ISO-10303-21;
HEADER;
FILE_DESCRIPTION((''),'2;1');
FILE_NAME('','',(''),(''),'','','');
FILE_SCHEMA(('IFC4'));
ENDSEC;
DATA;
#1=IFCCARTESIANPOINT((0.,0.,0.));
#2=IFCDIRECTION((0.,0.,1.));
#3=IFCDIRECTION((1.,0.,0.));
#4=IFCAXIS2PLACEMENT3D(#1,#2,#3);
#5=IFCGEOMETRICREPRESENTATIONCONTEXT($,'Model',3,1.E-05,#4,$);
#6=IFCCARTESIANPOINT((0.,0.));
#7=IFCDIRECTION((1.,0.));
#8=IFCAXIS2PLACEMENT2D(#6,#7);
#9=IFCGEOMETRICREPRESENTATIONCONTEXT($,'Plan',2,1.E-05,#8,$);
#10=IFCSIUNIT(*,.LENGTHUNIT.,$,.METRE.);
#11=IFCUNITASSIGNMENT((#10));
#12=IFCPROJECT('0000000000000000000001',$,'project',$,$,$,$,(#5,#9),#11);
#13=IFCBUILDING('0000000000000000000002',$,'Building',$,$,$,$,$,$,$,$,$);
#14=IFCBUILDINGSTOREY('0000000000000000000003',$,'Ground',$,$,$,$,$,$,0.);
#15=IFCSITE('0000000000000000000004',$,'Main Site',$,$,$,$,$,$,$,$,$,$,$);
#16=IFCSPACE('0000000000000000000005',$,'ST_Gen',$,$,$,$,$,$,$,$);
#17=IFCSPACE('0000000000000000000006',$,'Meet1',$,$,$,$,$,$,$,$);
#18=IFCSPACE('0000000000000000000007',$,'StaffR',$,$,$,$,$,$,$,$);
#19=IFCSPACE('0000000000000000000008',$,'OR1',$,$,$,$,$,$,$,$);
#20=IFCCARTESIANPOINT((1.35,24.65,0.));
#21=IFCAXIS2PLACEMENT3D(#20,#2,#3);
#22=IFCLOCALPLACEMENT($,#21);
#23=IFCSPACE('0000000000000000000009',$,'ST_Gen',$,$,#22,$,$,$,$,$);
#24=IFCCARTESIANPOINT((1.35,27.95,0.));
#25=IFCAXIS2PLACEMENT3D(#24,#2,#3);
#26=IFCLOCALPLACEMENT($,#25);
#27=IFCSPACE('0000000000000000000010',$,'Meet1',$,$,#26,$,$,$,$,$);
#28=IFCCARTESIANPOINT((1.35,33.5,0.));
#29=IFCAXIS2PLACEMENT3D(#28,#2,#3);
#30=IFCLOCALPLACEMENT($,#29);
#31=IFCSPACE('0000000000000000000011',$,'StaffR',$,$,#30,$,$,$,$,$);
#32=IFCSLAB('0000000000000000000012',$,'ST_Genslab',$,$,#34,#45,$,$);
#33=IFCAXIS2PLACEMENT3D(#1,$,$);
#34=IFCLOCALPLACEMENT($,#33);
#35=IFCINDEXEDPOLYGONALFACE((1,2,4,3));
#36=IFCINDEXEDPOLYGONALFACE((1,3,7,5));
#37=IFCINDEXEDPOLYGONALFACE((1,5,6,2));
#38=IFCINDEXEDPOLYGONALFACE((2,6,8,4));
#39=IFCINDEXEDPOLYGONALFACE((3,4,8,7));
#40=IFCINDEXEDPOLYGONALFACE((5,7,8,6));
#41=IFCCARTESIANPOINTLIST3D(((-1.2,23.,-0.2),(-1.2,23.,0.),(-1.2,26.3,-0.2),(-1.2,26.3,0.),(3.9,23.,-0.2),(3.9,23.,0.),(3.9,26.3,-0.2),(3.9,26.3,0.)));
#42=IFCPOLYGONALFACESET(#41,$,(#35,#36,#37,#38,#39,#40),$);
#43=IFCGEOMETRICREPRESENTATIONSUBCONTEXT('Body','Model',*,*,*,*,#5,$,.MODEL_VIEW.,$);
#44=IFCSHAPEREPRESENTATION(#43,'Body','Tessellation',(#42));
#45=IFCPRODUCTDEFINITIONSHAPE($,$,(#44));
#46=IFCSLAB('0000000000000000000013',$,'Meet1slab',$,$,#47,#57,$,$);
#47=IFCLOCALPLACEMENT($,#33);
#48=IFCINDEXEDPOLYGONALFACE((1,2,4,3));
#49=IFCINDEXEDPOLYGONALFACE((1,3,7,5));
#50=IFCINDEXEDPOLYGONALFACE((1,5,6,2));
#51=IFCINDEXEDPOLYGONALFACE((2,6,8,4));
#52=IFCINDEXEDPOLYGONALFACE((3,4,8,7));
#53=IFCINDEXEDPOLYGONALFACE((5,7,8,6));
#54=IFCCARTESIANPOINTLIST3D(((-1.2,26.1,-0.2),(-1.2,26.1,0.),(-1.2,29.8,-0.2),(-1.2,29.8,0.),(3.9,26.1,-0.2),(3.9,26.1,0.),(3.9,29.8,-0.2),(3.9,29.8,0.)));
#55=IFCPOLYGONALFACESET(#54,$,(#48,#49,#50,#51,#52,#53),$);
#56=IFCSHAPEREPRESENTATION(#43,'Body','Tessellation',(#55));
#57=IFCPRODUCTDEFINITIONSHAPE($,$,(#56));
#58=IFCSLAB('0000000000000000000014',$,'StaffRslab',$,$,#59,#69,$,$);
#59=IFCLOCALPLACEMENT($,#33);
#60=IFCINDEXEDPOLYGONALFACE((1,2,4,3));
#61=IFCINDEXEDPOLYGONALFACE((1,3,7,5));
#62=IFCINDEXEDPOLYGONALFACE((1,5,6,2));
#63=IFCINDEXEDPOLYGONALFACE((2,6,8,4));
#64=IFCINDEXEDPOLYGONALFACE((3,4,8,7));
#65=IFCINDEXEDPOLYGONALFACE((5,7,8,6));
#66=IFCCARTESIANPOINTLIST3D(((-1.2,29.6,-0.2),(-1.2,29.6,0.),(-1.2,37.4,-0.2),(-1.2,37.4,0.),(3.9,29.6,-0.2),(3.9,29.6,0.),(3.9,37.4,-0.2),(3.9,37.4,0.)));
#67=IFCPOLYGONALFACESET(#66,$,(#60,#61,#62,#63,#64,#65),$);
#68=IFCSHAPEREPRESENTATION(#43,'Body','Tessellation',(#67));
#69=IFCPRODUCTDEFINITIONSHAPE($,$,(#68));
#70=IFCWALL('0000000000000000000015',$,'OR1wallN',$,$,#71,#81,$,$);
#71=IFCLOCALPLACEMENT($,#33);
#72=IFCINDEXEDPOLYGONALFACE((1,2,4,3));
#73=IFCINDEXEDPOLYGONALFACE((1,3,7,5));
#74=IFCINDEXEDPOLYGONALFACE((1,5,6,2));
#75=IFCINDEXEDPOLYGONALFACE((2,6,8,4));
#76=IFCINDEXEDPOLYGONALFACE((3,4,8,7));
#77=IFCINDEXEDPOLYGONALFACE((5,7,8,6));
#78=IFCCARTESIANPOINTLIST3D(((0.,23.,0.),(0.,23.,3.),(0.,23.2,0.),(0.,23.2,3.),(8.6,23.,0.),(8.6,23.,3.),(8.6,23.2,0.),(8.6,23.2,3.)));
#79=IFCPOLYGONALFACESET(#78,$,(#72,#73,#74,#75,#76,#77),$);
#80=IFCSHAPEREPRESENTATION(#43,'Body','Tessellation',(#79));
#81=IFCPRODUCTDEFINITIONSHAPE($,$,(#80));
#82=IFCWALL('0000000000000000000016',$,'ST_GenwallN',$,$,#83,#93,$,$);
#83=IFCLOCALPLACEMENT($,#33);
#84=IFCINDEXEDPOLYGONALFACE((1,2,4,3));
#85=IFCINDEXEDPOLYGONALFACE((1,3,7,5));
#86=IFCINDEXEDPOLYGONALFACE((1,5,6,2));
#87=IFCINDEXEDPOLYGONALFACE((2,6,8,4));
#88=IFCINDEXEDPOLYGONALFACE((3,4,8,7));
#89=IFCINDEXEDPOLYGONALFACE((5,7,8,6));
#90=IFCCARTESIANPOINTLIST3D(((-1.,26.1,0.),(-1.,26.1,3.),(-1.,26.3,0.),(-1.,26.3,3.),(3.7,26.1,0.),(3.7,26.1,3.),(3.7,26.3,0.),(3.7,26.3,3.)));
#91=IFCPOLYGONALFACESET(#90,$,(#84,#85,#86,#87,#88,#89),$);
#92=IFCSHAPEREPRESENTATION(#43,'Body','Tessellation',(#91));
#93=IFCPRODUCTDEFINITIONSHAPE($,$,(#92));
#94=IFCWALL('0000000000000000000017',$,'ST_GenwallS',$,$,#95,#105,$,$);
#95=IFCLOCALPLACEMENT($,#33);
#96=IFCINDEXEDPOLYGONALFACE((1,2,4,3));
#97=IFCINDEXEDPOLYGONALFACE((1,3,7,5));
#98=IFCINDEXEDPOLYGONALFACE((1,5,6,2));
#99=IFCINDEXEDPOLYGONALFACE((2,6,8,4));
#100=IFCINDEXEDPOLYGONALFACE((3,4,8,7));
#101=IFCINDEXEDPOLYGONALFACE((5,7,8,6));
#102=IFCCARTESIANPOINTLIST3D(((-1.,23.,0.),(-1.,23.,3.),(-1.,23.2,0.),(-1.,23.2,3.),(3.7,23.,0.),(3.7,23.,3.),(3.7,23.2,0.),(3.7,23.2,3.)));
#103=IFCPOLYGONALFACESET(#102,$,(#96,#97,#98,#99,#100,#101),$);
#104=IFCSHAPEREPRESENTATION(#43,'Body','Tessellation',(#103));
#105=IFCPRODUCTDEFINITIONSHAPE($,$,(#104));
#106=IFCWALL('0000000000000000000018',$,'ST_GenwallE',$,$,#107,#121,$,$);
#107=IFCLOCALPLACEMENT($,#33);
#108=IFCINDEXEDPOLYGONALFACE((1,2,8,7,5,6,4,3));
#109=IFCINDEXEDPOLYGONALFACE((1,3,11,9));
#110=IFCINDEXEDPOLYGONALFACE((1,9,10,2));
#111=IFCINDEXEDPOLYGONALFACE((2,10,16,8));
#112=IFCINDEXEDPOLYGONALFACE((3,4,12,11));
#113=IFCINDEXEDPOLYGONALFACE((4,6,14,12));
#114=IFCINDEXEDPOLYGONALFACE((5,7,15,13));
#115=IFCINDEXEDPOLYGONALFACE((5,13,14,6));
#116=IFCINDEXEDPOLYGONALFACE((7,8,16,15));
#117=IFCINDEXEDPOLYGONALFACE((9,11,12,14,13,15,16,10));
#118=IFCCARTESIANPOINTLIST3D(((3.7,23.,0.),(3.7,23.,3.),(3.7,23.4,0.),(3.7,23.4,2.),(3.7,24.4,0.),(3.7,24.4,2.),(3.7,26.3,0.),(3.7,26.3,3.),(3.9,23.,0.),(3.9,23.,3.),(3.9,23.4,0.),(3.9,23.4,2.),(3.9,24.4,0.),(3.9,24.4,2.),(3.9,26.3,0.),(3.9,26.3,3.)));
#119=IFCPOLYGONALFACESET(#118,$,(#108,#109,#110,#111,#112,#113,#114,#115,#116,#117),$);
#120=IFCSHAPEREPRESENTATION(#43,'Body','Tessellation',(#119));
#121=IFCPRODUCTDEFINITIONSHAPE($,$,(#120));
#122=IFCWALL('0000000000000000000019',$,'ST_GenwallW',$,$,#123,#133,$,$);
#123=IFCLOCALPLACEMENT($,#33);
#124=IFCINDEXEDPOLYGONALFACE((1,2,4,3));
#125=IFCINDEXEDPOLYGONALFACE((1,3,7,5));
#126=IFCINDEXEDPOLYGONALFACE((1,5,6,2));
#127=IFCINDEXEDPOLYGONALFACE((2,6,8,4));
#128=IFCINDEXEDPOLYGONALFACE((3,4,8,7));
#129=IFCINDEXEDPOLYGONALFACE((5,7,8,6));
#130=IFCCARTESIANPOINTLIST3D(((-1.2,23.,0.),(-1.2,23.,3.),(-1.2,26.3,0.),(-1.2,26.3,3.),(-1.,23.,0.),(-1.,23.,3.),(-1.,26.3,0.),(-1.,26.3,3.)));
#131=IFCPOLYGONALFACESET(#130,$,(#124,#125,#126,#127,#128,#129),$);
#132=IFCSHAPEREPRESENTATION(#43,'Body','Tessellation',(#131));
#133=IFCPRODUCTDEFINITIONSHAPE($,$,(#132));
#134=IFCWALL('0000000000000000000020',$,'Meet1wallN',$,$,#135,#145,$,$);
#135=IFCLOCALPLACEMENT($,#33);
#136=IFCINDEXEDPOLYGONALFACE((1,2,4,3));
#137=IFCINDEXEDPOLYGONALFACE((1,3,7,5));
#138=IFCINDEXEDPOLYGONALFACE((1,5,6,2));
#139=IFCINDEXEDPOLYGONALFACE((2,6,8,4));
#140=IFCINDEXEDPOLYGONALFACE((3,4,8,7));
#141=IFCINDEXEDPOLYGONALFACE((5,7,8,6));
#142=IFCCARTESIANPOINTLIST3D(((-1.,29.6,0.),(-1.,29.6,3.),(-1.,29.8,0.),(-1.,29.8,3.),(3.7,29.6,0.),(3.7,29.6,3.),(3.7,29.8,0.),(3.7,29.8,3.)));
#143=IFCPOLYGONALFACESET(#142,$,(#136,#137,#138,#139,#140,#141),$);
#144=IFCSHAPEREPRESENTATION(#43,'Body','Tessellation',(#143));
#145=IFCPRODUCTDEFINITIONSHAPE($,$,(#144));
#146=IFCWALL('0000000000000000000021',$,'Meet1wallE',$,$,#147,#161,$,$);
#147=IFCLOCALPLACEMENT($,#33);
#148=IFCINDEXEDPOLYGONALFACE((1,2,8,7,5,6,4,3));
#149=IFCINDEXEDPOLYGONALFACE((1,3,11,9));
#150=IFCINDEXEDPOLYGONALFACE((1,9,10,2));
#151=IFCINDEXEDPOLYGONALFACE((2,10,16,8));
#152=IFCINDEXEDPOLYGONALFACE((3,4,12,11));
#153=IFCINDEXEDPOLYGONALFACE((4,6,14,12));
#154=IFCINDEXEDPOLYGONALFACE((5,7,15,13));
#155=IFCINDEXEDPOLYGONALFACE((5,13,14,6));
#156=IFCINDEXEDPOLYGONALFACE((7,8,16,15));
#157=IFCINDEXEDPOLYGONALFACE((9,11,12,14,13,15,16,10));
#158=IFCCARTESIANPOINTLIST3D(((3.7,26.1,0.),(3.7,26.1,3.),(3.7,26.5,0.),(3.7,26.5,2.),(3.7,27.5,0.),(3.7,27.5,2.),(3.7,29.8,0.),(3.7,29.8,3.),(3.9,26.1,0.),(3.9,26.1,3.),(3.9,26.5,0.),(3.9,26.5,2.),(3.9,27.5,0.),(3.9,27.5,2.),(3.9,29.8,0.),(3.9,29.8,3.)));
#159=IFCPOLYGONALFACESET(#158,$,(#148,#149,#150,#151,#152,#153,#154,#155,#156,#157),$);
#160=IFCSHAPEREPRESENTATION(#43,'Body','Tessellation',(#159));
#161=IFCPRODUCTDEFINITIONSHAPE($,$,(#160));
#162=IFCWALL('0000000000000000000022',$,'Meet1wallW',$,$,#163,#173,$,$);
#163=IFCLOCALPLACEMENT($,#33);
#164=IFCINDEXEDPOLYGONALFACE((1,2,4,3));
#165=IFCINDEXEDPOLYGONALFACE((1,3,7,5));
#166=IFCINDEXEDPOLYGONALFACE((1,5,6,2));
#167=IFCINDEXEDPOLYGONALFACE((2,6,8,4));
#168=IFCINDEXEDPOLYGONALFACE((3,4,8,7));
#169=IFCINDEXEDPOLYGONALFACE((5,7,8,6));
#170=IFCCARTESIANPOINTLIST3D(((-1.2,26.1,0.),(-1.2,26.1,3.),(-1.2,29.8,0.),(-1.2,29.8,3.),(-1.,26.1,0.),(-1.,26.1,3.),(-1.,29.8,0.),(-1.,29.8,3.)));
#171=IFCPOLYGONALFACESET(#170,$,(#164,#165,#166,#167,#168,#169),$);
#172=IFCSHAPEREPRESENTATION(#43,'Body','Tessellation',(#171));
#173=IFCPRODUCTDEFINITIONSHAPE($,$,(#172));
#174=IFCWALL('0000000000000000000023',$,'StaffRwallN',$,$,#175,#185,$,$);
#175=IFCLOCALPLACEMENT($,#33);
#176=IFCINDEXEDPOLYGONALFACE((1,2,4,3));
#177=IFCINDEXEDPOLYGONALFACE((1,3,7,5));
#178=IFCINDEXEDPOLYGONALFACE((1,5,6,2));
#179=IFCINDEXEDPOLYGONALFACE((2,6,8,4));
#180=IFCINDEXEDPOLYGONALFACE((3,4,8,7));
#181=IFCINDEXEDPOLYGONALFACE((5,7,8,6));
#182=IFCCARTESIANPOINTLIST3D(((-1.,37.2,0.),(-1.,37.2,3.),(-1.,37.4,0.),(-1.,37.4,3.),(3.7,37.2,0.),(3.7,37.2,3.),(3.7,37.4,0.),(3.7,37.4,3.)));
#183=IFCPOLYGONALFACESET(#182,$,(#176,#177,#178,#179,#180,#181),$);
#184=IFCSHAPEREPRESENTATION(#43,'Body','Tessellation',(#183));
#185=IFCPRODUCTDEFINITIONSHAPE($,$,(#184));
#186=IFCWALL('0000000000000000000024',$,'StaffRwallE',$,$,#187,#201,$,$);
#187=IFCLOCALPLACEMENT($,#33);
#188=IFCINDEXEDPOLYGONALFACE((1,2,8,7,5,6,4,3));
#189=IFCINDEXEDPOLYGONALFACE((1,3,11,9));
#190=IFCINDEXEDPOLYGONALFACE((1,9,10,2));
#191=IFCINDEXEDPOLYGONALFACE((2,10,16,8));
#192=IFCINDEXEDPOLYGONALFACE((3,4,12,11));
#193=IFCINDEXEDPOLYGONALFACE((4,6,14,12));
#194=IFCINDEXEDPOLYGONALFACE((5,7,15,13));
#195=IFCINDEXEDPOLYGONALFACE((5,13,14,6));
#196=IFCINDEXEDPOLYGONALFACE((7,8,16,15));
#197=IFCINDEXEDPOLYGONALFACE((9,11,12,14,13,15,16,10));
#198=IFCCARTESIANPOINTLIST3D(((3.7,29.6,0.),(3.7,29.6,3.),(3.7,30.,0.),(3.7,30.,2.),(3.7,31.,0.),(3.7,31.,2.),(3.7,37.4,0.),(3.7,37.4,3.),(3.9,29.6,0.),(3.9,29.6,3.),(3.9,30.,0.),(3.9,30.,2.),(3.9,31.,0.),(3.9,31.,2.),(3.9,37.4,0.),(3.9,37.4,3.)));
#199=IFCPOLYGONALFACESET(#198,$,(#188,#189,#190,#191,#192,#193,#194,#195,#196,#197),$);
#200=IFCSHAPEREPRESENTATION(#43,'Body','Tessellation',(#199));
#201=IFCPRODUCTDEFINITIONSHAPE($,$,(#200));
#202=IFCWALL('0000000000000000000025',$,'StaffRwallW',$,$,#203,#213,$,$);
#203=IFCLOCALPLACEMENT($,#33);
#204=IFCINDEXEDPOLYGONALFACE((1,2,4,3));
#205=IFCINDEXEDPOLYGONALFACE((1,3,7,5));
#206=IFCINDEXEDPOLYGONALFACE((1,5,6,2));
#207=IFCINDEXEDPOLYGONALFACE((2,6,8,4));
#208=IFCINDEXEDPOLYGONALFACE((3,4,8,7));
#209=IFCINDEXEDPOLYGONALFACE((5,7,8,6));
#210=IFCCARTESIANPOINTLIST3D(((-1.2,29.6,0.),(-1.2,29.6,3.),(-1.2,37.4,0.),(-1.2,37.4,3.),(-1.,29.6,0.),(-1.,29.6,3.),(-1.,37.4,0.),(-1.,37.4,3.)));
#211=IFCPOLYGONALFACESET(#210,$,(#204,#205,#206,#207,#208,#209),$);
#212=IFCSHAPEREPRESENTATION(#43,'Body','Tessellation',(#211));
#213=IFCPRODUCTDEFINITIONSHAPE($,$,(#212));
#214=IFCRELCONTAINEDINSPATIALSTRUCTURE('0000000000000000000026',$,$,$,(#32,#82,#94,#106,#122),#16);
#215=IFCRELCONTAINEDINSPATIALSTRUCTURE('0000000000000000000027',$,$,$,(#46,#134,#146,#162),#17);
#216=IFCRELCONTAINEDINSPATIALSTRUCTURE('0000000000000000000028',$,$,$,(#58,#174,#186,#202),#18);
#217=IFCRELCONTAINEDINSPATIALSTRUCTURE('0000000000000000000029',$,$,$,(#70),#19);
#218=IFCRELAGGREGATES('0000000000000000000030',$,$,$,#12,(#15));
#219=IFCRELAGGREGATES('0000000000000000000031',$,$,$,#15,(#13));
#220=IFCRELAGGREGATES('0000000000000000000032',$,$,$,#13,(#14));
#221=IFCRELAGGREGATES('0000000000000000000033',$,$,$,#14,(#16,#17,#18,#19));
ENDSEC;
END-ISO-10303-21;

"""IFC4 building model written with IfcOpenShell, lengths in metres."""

from ifc_helpers import new_model, si_unit, frame, origin_with_axes, origin_2d_with_axis, place, context, subcontext, project, spatial, indexed_curve, rectangle, outline, extrude, element, save


model = new_model("IFC4")

# Units and contexts
model_context = context("Model", 3, precision=1e-05, world=origin_with_axes())
plan_context = context("Plan", 2, precision=1e-05, world=origin_2d_with_axis())
body_context = subcontext(model_context, "Body", "Model", "MODEL_VIEW")
ifc_project = project(units=[si_unit("LENGTHUNIT", "METRE")], contexts=[model_context, plan_context])

# Site, building, storey, space
site = spatial("IfcSite", under=ifc_project, Name="Main Site")
building = spatial("IfcBuilding", under=site, Name="Building")
storey = spatial("IfcBuildingStorey", under=building, Name="Ground", Elevation=0.0)
space_1 = spatial("IfcSpace", under=storey, Name="ST_Gen")

# Slab
slab_1_placement = place(None, frame((1.35, 24.65, -0.2), z_axis=(0.0, 0.0, 1.0), x_axis=(1.0, 0.0, 0.0)))
element("IfcSlab", 1, at=slab_1_placement, inside=space_1, Name="ST_Genslab", context=body_context, shape_type="SweptSolid", body=[
    extrude(rectangle(XDim=5.1, YDim=3.3), origin_with_axes(), (0.0, 0.0, 1.0), 0.2),
])

# Shared definitions
space_2 = spatial("IfcSpace", under=storey, Name="Meet1")

# Slab
slab_2_placement = place(None, frame((1.35, 27.95, -0.2), z_axis=(0.0, 0.0, 1.0), x_axis=(1.0, 0.0, 0.0)))
element("IfcSlab", 2, at=slab_2_placement, inside=space_2, Name="Meet1slab", context=body_context, shape_type="SweptSolid", body=[
    extrude(rectangle(XDim=5.1, YDim=3.7), origin_with_axes(), (0.0, 0.0, 1.0), 0.2),
])

# Shared definitions
space_3 = spatial("IfcSpace", under=storey, Name="StaffR")

# Slab
slab_3_placement = place(None, frame((1.35, 33.5, -0.2), z_axis=(0.0, 0.0, 1.0), x_axis=(1.0, 0.0, 0.0)))
element("IfcSlab", 3, at=slab_3_placement, inside=space_3, Name="StaffRslab", context=body_context, shape_type="SweptSolid", body=[
    extrude(rectangle(XDim=5.1, YDim=7.8), origin_with_axes(), (0.0, 0.0, 1.0), 0.2),
])

# Shared definitions
space_4 = spatial("IfcSpace", under=storey, Name="OR1")

# Walls
wall_1_placement = place(None, frame((0.0, 23.0, 0.0), z_axis=(0.0, 0.0, 1.0), x_axis=(1.0, 0.0, 0.0)))
element("IfcWall", 4, at=wall_1_placement, inside=space_4, Name="OR1wallN", context=body_context, shape_type="SweptSolid", body=[
    extrude(outline(indexed_curve([(0.0, 0.0), (0.0, 0.2), (8.6, 0.2), (8.6, 0.0), (0.0, 0.0)], self_intersect=False)), origin_with_axes(), (0.0, 0.0, 1.0), 3.0),
])
for number, where, z_axis, x_axis, name in (
    (5, (-1.0, 26.1, 0.0), (0.0, 0.0, 1.0), (1.0, 0.0, 0.0), "ST_GenwallN"),
    (6, (-1.0, 23.0, 0.0), (0.0, 0.0, 1.0), (1.0, 0.0, 0.0), "ST_GenwallS"),
):
    element("IfcWall", number, at=place(None, frame(where, z_axis=z_axis, x_axis=x_axis)), inside=space_1, Name=name, context=body_context, shape_type="SweptSolid", body=[
        extrude(outline(indexed_curve([(0.0, 0.0), (0.0, 0.2), (4.7, 0.2), (4.7, 0.0), (0.0, 0.0)], self_intersect=False)), origin_with_axes(), (0.0, 0.0, 1.0), 3.0),
    ])

# Wall
wall_2_placement = place(None, frame((3.9, 23.0, 0.0), z_axis=(0.0, 0.0, 1.0), x_axis=(0.0, 1.0, 0.0)))
wall_2 = element("IfcWall", 7, at=wall_2_placement, inside=space_1, Name="ST_GenwallE", context=body_context, shape_type="SweptSolid", body=[
    extrude(outline(indexed_curve([(0.0, 0.0), (0.0, 0.2), (3.3, 0.2), (3.3, 0.0), (0.0, 0.0)], self_intersect=False)), origin_with_axes(), (0.0, 0.0, 1.0), 3.0),
])

# Shared definitions
space_5_placement = place(None, frame((1.35, 24.65, 0.0), z_axis=(0.0, 0.0, 1.0), x_axis=(1.0, 0.0, 0.0)))
space_5 = spatial("IfcSpace", at=space_5_placement, Name="ST_Gen")

# Opening
opening_1_placement = place(wall_2_placement, frame((0.4, 0.0, 0.0), z_axis=(0.0, 0.0, 1.0), x_axis=(1.0, 0.0, 0.0)))
element("IfcOpeningElement", 8, at=opening_1_placement, inside=space_5, cuts=wall_2, context=body_context, shape_type="SweptSolid", body=[
    extrude(outline(indexed_curve([(0.0, 0.0), (0.0, 0.4), (1.0, 0.4), (1.0, 0.0), (0.0, 0.0)], self_intersect=False)), origin_with_axes(), (0.0, 0.0, 1.0), 2.0),
])

# Walls
wall_3_placement = place(None, frame((-1.0, 23.0, 0.0), z_axis=(0.0, 0.0, 1.0), x_axis=(0.0, 1.0, 0.0)))
element("IfcWall", 9, at=wall_3_placement, inside=space_1, Name="ST_GenwallW", context=body_context, shape_type="SweptSolid", body=[
    extrude(outline(indexed_curve([(0.0, 0.0), (0.0, 0.2), (3.3, 0.2), (3.3, 0.0), (0.0, 0.0)], self_intersect=False)), origin_with_axes(), (0.0, 0.0, 1.0), 3.0),
])
for number, where, z_axis, x_axis, name in (
    (10, (-1.0, 29.6, 0.0), (0.0, 0.0, 1.0), (1.0, 0.0, 0.0), "Meet1wallN"),
):
    element("IfcWall", number, at=place(None, frame(where, z_axis=z_axis, x_axis=x_axis)), inside=space_2, Name=name, context=body_context, shape_type="SweptSolid", body=[
        extrude(outline(indexed_curve([(0.0, 0.0), (0.0, 0.2), (4.7, 0.2), (4.7, 0.0), (0.0, 0.0)], self_intersect=False)), origin_with_axes(), (0.0, 0.0, 1.0), 3.0),
    ])

# Wall
wall_4_placement = place(None, frame((3.9, 26.1, 0.0), z_axis=(0.0, 0.0, 1.0), x_axis=(0.0, 1.0, 0.0)))
wall_4 = element("IfcWall", 11, at=wall_4_placement, inside=space_2, Name="Meet1wallE", context=body_context, shape_type="SweptSolid", body=[
    extrude(outline(indexed_curve([(0.0, 0.0), (0.0, 0.2), (3.7, 0.2), (3.7, 0.0), (0.0, 0.0)], self_intersect=False)), origin_with_axes(), (0.0, 0.0, 1.0), 3.0),
])

# Shared definitions
space_6_placement = place(None, frame((1.35, 27.95, 0.0), z_axis=(0.0, 0.0, 1.0), x_axis=(1.0, 0.0, 0.0)))
space_6 = spatial("IfcSpace", at=space_6_placement, Name="Meet1")

# Opening
opening_2_placement = place(wall_4_placement, frame((0.4, 0.0, 0.0), z_axis=(0.0, 0.0, 1.0), x_axis=(1.0, 0.0, 0.0)))
element("IfcOpeningElement", 12, at=opening_2_placement, inside=space_6, cuts=wall_4, context=body_context, shape_type="SweptSolid", body=[
    extrude(outline(indexed_curve([(0.0, 0.0), (0.0, 0.4), (1.0, 0.4), (1.0, 0.0), (0.0, 0.0)], self_intersect=False)), origin_with_axes(), (0.0, 0.0, 1.0), 2.0),
])

# Walls
wall_5_placement = place(None, frame((-1.0, 26.1, 0.0), z_axis=(0.0, 0.0, 1.0), x_axis=(0.0, 1.0, 0.0)))
element("IfcWall", 13, at=wall_5_placement, inside=space_2, Name="Meet1wallW", context=body_context, shape_type="SweptSolid", body=[
    extrude(outline(indexed_curve([(0.0, 0.0), (0.0, 0.2), (3.7, 0.2), (3.7, 0.0), (0.0, 0.0)], self_intersect=False)), origin_with_axes(), (0.0, 0.0, 1.0), 3.0),
])
for number, where, z_axis, x_axis, name in (
    (14, (-1.0, 37.2, 0.0), (0.0, 0.0, 1.0), (1.0, 0.0, 0.0), "StaffRwallN"),
):
    element("IfcWall", number, at=place(None, frame(where, z_axis=z_axis, x_axis=x_axis)), inside=space_3, Name=name, context=body_context, shape_type="SweptSolid", body=[
        extrude(outline(indexed_curve([(0.0, 0.0), (0.0, 0.2), (4.7, 0.2), (4.7, 0.0), (0.0, 0.0)], self_intersect=False)), origin_with_axes(), (0.0, 0.0, 1.0), 3.0),
    ])

# Wall
wall_6_placement = place(None, frame((3.9, 29.6, 0.0), z_axis=(0.0, 0.0, 1.0), x_axis=(0.0, 1.0, 0.0)))
wall_6 = element("IfcWall", 15, at=wall_6_placement, inside=space_3, Name="StaffRwallE", context=body_context, shape_type="SweptSolid", body=[
    extrude(outline(indexed_curve([(0.0, 0.0), (0.0, 0.2), (7.8, 0.2), (7.8, 0.0), (0.0, 0.0)], self_intersect=False)), origin_with_axes(), (0.0, 0.0, 1.0), 3.0),
])

# Shared definitions
space_7_placement = place(None, frame((1.35, 33.5, 0.0), z_axis=(0.0, 0.0, 1.0), x_axis=(1.0, 0.0, 0.0)))
space_7 = spatial("IfcSpace", at=space_7_placement, Name="StaffR")

# Opening
opening_3_placement = place(wall_6_placement, frame((0.4, 0.0, 0.0), z_axis=(0.0, 0.0, 1.0), x_axis=(1.0, 0.0, 0.0)))
element("IfcOpeningElement", 16, at=opening_3_placement, inside=space_7, cuts=wall_6, context=body_context, shape_type="SweptSolid", body=[
    extrude(outline(indexed_curve([(0.0, 0.0), (0.0, 0.4), (1.0, 0.4), (1.0, 0.0), (0.0, 0.0)], self_intersect=False)), origin_with_axes(), (0.0, 0.0, 1.0), 2.0),
])

# Wall
wall_7_placement = place(None, frame((-1.0, 29.6, 0.0), z_axis=(0.0, 0.0, 1.0), x_axis=(0.0, 1.0, 0.0)))
element("IfcWall", 17, at=wall_7_placement, inside=space_3, Name="StaffRwallW", context=body_context, shape_type="SweptSolid", body=[
    extrude(outline(indexed_curve([(0.0, 0.0), (0.0, 0.2), (7.8, 0.2), (7.8, 0.0), (0.0, 0.0)], self_intersect=False)), origin_with_axes(), (0.0, 0.0, 1.0), 3.0),
])

save(model, "model.ifc")
